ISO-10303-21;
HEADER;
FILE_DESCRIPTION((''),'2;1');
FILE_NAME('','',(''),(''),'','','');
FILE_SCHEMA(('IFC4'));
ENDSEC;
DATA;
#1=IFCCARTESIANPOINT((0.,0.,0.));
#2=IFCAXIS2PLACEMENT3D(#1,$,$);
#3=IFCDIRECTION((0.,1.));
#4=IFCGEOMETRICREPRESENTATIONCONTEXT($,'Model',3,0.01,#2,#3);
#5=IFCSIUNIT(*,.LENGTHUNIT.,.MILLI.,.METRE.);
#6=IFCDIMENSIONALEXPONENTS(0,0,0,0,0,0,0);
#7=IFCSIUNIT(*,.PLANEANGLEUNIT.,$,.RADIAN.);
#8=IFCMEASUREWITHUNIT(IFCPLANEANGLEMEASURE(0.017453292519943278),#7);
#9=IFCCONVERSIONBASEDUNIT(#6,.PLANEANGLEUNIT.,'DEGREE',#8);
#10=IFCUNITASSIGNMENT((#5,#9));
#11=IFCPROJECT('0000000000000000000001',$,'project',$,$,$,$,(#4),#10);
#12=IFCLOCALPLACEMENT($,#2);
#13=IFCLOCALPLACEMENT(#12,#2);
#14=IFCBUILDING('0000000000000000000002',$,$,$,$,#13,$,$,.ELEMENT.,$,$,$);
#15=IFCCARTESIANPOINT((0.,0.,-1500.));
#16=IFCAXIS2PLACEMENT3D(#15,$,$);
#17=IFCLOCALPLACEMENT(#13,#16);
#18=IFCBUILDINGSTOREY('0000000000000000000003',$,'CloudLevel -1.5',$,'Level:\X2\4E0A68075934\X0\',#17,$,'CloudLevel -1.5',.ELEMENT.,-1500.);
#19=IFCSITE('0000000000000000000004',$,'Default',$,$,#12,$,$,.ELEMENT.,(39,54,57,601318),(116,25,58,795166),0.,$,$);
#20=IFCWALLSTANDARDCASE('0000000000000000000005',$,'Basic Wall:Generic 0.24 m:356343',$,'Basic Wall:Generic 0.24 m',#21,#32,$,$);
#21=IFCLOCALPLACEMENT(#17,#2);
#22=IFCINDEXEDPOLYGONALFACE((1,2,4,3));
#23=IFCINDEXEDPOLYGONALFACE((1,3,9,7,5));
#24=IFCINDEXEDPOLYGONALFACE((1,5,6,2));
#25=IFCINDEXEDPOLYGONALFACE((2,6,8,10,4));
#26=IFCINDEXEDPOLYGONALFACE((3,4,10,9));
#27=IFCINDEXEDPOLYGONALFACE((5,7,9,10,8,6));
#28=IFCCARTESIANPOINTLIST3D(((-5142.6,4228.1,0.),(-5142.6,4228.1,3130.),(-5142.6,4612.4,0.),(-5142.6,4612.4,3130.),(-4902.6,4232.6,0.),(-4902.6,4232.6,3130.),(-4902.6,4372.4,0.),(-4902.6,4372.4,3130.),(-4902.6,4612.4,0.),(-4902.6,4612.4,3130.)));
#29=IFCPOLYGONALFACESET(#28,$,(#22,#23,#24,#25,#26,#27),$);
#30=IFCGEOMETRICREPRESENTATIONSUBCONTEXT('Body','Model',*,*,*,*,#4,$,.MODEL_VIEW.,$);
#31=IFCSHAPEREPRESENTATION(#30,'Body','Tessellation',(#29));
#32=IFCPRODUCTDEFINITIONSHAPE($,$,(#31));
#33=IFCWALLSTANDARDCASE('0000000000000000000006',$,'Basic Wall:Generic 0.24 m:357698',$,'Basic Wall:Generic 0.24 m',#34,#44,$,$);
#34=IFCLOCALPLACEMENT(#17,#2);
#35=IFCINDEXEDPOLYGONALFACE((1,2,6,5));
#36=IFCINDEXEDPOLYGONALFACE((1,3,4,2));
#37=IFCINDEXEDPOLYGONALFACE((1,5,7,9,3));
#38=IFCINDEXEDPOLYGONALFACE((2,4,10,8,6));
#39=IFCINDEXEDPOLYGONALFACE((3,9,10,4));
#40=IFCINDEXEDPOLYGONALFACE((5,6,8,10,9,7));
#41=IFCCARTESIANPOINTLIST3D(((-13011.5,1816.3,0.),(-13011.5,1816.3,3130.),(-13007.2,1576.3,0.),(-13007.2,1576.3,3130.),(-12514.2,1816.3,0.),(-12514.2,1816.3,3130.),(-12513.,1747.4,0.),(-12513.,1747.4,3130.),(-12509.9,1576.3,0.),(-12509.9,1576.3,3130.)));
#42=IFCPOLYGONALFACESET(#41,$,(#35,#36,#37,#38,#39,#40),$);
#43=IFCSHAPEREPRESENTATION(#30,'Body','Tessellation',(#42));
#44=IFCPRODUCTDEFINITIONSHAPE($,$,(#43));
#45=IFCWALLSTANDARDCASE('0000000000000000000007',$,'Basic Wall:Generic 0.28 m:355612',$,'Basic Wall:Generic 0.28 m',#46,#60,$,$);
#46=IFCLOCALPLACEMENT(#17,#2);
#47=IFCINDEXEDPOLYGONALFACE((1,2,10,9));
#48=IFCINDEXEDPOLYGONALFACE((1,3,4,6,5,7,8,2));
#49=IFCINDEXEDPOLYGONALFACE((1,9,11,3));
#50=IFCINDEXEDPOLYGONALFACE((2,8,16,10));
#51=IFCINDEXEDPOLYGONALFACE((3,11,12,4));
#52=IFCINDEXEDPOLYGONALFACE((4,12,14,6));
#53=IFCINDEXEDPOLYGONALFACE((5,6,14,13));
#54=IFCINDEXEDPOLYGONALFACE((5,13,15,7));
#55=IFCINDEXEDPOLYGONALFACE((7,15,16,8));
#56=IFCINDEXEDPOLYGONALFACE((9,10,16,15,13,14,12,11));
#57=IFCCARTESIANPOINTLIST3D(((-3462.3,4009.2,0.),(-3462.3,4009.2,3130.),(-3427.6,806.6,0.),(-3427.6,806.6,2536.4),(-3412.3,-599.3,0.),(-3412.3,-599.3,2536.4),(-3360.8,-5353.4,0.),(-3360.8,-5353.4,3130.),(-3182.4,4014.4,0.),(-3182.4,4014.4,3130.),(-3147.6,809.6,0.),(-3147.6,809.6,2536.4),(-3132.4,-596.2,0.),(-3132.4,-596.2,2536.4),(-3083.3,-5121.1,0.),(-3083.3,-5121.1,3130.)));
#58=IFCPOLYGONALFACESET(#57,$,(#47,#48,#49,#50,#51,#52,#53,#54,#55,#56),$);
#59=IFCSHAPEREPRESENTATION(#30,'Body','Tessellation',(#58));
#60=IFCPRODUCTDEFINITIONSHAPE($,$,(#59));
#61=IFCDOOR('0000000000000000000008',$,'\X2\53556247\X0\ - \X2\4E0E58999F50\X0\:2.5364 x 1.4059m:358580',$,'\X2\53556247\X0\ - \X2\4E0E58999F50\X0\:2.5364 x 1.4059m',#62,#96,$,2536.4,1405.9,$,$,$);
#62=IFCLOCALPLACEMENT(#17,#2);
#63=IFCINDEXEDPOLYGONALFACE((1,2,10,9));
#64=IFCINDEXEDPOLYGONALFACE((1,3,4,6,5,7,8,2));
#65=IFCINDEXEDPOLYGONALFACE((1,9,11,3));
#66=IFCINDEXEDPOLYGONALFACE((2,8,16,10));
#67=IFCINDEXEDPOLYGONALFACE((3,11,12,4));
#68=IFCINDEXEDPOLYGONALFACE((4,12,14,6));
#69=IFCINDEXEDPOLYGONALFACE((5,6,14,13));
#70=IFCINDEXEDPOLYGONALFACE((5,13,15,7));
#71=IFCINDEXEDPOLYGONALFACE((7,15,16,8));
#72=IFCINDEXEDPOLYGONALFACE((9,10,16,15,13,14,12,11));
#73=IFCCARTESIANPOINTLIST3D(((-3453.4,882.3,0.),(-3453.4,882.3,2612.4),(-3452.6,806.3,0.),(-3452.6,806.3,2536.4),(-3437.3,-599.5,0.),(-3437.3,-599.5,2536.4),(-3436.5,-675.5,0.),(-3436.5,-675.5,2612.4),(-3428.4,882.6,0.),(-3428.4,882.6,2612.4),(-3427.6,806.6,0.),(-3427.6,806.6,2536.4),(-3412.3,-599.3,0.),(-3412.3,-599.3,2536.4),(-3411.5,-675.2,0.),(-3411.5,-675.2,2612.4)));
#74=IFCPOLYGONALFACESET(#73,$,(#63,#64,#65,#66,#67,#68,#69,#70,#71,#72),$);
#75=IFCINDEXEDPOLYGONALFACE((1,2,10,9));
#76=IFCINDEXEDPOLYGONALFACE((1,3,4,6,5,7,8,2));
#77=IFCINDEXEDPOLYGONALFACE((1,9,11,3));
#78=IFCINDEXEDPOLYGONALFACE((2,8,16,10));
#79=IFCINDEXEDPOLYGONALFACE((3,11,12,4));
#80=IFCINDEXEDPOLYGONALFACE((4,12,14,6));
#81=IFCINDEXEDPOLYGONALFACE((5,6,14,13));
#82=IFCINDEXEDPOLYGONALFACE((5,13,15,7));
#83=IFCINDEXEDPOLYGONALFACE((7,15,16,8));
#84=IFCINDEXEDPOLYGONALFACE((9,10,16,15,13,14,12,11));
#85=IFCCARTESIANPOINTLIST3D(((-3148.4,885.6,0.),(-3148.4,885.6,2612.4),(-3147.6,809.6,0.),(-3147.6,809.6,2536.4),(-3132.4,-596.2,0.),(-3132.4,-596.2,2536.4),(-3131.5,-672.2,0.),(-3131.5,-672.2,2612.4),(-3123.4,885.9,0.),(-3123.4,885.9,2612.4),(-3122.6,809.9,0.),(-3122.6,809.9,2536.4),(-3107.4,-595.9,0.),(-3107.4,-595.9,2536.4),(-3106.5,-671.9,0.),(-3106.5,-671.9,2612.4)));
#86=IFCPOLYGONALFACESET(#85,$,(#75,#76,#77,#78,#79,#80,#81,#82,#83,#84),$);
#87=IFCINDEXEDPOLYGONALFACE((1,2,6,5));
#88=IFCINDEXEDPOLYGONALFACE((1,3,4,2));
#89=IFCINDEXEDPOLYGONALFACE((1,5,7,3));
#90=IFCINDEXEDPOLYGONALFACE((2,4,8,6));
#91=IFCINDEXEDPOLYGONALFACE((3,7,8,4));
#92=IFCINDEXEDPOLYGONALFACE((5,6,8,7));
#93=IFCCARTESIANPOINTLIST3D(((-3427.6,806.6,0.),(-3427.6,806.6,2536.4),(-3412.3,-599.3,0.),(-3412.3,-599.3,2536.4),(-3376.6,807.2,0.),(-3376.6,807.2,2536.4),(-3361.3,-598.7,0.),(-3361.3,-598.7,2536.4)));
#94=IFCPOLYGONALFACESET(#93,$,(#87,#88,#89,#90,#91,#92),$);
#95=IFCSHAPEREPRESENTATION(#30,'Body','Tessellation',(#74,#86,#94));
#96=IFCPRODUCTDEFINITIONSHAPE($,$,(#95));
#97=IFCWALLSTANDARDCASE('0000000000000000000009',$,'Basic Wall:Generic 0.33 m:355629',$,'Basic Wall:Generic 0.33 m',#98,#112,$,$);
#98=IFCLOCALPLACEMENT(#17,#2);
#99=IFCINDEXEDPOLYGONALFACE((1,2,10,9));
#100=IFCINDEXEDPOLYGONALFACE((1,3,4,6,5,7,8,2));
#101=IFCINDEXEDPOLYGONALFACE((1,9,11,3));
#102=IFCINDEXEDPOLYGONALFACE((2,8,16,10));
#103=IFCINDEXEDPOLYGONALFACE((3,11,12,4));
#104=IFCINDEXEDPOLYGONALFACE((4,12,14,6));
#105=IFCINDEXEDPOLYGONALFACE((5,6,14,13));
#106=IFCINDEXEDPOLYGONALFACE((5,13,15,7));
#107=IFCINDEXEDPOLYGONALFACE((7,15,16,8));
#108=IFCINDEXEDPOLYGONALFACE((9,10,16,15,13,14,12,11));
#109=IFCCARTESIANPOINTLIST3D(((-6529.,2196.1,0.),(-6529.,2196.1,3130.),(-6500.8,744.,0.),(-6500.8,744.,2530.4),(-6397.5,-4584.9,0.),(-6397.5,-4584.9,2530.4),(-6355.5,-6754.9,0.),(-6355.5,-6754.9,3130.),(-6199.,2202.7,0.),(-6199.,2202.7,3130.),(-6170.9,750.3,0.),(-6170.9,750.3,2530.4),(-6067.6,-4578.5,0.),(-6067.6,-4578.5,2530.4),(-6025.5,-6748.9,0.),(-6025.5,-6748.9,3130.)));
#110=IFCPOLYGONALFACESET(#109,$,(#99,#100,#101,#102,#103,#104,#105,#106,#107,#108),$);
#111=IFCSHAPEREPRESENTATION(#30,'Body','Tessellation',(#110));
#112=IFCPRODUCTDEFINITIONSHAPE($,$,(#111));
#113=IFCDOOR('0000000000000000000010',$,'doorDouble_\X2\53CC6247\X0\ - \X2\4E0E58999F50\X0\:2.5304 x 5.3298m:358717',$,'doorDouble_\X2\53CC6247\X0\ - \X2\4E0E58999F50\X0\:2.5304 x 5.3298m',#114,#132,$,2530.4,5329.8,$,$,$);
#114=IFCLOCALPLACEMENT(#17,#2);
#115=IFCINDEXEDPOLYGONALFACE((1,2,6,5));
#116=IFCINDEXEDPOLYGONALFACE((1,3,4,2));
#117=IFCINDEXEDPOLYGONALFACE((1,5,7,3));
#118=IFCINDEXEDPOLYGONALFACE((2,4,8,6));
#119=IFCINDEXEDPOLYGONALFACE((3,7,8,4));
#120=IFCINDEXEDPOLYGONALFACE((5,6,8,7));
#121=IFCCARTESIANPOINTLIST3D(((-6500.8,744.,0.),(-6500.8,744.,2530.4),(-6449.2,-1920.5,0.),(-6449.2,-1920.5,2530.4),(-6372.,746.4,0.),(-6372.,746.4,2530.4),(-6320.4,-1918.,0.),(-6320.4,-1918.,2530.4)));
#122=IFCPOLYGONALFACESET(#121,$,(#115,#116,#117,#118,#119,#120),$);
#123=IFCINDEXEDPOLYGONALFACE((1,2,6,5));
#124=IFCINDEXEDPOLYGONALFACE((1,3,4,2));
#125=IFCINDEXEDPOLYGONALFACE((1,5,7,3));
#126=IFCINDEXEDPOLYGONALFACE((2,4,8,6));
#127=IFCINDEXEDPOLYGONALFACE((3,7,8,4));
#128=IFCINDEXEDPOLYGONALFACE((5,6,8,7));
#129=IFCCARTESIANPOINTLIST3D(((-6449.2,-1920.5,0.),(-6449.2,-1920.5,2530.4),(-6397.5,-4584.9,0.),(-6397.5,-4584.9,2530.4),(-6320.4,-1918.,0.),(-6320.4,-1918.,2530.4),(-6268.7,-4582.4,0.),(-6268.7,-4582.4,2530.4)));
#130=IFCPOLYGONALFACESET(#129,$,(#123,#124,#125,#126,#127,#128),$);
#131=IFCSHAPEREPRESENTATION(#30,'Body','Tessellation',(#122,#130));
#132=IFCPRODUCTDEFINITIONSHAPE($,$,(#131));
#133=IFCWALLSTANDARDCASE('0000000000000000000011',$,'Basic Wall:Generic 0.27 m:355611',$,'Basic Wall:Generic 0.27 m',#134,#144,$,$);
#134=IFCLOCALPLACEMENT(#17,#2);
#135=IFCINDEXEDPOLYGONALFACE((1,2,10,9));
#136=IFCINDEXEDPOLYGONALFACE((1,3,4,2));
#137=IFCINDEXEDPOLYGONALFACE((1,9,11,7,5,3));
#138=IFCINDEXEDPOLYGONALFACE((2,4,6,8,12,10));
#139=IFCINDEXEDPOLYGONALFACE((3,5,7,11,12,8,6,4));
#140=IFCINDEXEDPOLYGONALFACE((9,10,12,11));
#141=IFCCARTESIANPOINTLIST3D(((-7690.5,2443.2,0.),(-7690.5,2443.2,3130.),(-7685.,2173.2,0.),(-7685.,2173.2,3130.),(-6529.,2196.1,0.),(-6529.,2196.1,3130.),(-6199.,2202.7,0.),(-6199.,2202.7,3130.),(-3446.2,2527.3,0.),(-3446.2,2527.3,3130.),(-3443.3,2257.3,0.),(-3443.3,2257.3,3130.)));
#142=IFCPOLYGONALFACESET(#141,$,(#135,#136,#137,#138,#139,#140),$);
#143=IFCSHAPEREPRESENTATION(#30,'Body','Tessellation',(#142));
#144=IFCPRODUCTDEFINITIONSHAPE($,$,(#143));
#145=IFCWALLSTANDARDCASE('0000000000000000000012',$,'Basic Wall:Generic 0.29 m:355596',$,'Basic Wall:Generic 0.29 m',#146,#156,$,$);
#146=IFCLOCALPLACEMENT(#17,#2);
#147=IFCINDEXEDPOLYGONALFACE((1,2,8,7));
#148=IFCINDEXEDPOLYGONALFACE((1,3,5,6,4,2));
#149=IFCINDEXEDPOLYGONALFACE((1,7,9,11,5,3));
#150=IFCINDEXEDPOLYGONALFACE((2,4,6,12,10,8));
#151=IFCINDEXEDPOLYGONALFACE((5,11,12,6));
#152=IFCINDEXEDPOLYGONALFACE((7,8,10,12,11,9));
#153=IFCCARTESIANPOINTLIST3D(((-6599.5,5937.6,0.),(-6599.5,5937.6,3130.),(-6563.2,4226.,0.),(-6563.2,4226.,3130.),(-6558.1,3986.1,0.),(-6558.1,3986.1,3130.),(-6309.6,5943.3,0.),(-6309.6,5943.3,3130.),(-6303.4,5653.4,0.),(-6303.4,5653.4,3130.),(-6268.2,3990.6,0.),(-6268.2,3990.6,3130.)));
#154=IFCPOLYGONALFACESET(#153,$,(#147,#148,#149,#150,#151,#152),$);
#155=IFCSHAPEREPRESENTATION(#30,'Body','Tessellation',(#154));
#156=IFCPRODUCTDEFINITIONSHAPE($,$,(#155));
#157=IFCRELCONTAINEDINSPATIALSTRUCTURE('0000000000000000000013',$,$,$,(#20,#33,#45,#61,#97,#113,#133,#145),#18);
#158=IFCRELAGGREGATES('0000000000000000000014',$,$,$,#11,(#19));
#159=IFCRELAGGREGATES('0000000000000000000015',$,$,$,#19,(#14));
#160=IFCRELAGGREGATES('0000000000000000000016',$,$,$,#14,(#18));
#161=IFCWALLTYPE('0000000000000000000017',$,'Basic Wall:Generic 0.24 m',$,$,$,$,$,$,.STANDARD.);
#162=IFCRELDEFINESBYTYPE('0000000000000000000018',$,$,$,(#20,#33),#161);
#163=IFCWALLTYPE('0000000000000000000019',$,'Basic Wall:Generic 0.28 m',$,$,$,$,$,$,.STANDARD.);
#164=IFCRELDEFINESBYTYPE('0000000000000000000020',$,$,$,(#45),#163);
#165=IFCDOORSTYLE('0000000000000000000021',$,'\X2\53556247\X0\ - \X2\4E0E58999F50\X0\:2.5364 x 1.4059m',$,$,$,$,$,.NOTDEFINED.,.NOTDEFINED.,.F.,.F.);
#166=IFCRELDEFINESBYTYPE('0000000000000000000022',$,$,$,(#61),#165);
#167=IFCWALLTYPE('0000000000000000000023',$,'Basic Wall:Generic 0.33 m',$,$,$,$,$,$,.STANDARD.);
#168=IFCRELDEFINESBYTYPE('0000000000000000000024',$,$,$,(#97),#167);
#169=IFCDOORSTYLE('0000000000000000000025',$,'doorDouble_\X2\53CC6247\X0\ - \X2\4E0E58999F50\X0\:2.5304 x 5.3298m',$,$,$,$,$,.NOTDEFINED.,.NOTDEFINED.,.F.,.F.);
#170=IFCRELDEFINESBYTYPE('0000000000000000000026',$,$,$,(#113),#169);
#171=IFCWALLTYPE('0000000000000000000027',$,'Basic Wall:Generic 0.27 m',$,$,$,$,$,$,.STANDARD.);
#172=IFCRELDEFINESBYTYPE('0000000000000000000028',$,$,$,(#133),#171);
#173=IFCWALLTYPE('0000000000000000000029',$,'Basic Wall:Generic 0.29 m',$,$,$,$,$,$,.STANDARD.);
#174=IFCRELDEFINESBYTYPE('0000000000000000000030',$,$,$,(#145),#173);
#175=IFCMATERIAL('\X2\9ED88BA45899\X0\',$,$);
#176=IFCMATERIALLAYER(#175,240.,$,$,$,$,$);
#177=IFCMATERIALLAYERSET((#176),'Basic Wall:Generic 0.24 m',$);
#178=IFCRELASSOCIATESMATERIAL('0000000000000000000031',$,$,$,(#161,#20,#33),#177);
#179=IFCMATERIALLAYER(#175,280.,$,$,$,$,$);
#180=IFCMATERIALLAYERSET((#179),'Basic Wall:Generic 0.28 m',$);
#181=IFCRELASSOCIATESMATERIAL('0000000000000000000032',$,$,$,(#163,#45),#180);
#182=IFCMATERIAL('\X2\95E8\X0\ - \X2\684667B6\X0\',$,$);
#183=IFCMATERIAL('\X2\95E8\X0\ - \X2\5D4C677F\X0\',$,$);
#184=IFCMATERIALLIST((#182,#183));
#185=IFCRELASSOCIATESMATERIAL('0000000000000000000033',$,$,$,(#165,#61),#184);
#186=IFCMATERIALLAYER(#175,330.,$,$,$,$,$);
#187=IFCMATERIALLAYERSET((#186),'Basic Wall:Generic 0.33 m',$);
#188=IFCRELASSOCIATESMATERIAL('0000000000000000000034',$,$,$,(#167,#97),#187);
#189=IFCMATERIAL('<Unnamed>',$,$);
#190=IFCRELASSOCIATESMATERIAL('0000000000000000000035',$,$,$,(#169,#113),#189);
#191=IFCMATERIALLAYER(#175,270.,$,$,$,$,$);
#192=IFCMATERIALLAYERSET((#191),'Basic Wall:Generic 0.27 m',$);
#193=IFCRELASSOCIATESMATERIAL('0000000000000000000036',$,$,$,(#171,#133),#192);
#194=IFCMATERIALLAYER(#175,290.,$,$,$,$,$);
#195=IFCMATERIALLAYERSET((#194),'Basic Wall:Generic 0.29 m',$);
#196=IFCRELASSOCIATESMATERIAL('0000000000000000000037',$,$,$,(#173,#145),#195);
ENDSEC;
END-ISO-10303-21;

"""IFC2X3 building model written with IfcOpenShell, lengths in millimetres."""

from ifc_helpers import new_model, entity, si_unit, converted_unit, direction, frame, frame_2d, origin, origin_2d_with_axis, place, context, subcontext, project, spatial, polyline, rectangle, outline, extrude, source, transform, mapped, material, material_list, layer, layer_set, layer_usage, type_object, type_shapes, element, fill, save


model = new_model("IFC2X3")

# Units and contexts
model_context = context("Model", 3, precision=0.01, world=origin(), true_north=direction((0.0, 1.0)))
body_context = subcontext(model_context, "Body", "Model", "MODEL_VIEW")
ifc_project = project(units=[si_unit("LENGTHUNIT", "METRE", prefix="MILLI"), converted_unit("PLANEANGLEUNIT", "DEGREE", entity("IfcPlaneAngleMeasure", 0.017453292519943278), si_unit("PLANEANGLEUNIT", "RADIAN"), dimensions=[0, 0, 0, 0, 0, 0, 0])], contexts=[model_context])

# Site, building, storey
site_placement = place(None, origin())
site = spatial("IfcSite", under=ifc_project, at=site_placement, Name="Default", CompositionType="ELEMENT", RefLatitude=(39, 54, 57, 601318), RefLongitude=(116, 25, 58, 795166), RefElevation=0.0)
building_placement = place(site_placement, origin())
building = spatial("IfcBuilding", under=site, at=building_placement, CompositionType="ELEMENT")
storey_placement = place(building_placement, frame((0.0, 0.0, -1500.0)))
storey = spatial("IfcBuildingStorey", under=building, at=storey_placement, Name="CloudLevel -1.5", ObjectType="Level:上标头", LongName="CloudLevel -1.5", CompositionType="ELEMENT", Elevation=-1500.0)

# Shared definitions
ifc_material_1 = material(Name="默认墙")
ifc_layer_1 = layer(ifc_material_1, 240.0)
ifc_layer_set_1 = layer_set([ifc_layer_1], Name="Basic Wall:Generic 0.24 m")
ifc_layer_usage_1 = layer_usage(ifc_layer_set_1, "AXIS2", "NEGATIVE", 120.0)
wall_type_1 = type_object("IfcWallType", Name="Basic Wall:Generic 0.24 m", PredefinedType="STANDARD", material=ifc_layer_set_1)
ifc_material_2 = material(Name="门 - 框架")
ifc_material_3 = material(Name="门 - 嵌板")
ifc_material_list_1 = material_list([ifc_material_2, ifc_material_3])

# Shared definitions
ifc_material_4 = material(Name="<Unnamed>")

# Walls
wall_1_placement = place(storey_placement, frame((-5022.6, 4612.4, 0.0), z_axis=(0.0, 0.0, 1.0), x_axis=(0.0, -1.0, 0.0)))
element("IfcWallStandardCase", 1, at=wall_1_placement, inside=storey, type_object=wall_type_1, material=ifc_layer_usage_1, Name="Basic Wall:Generic 0.24 m:356343", ObjectType="Basic Wall:Generic 0.24 m", context=body_context, shape_type="SweptSolid", body=[
    extrude(outline(polyline([(384.2, -120.0), (379.8, 120.0), (240.0, 120.0), (0.0, 120.0), (0.0, -120.0), (384.2, -120.0)])), origin(), (0.0, 0.0, 1.0), 3130.0),
])
wall_2_placement = place(storey_placement, frame((-13011.5, 1696.3, 0.0)))
element("IfcWallStandardCase", 2, at=wall_2_placement, inside=storey, type_object=wall_type_1, material=ifc_layer_usage_1, Name="Basic Wall:Generic 0.24 m:357698", ObjectType="Basic Wall:Generic 0.24 m", context=body_context, shape_type="SweptSolid", body=[
    extrude(outline(polyline([(501.6, -120.0), (498.5, 51.1), (497.3, 120.0), (0.0, 120.0), (4.3, -120.0), (501.6, -120.0)])), origin(), (0.0, 0.0, 1.0), 3130.0),
])

# Walls, openings, doors
ifc_layer_2 = layer(ifc_material_1, 280.0)
ifc_layer_set_2 = layer_set([ifc_layer_2], Name="Basic Wall:Generic 0.28 m")
ifc_layer_usage_2 = layer_usage(ifc_layer_set_2, "AXIS2", "NEGATIVE", 140.0)
wall_type_2 = type_object("IfcWallType", Name="Basic Wall:Generic 0.28 m", PredefinedType="STANDARD", material=ifc_layer_set_2)
wall_3_placement = place(storey_placement, frame((-3322.3, 4012.9, 0.0), z_axis=(0.0, 0.0, 1.0), x_axis=(0.010843, -0.999941, 0.0)))
wall_3 = element("IfcWallStandardCase", 3, at=wall_3_placement, inside=storey, type_object=wall_type_2, material=ifc_layer_usage_2, Name="Basic Wall:Generic 0.28 m:355612", ObjectType="Basic Wall:Generic 0.28 m", context=body_context, shape_type="SweptSolid", body=[
    extrude(outline(polyline([(2.1, -140.0), (1484.2, -140.0), (1754.2, -140.0), (9365.3, -140.0), (9136.0, 140.0), (8537.2, 140.0), (0.0, 140.0), (2.1, -140.0)])), origin(), (0.0, 0.0, 1.0), 3130.0),
])
opening_1_placement = place(wall_3_placement, frame((4610.9, 140.0, 0.0)))
opening_1 = element("IfcOpeningElement", 4, at=opening_1_placement, cuts=wall_3, ObjectType="Opening", context=body_context, shape_type="SweptSolid", body=[
    extrude(rectangle(XDim=1405.9, YDim=2536.4, at=frame_2d((1268.2, 703.0), x_axis=(0.0, -1.0))), frame((0.0, 0.0, 0.0), z_axis=(0.0, -1.0, 0.0), x_axis=(0.0, 0.0, 1.0)), (0.0, 0.0, 1.0), 280.0),
])
door_style_1 = type_object("IfcDoorStyle", Name="单扇 - 与墙齐:2.5364 x 1.4059m", ConstructionType="NOTDEFINED", OperationType="NOTDEFINED", ParameterTakesPrecedence=False, Sizeable=False, material=ifc_material_list_1)
shared_shape_1 = source(origin(), body_context, "Body", "SweptSolid", [
    extrude(outline(polyline([(-779.0, -1325.2), (779.0, -1325.2), (779.0, 1287.2), (703.0, 1287.2), (703.0, -1249.2), (-703.0, -1249.2), (-703.0, 1287.2), (-779.0, 1287.2), (-779.0, -1325.2)])), frame((703.0, 305.0, 1287.2), z_axis=(0.0, -1.0, 0.0), x_axis=(-1.0, 0.0, 0.0)), (0.0, 0.0, 1.0), 25.0),
    extrude(outline(polyline([(-1325.2, -779.0), (1287.2, -779.0), (1287.2, -703.0), (-1249.2, -703.0), (-1249.2, 703.0), (1287.2, 703.0), (1287.2, 779.0), (-1325.2, 779.0), (-1325.2, -779.0)])), frame((703.0, 0.0, 1287.2), z_axis=(0.0, -1.0, 0.0), x_axis=(0.0, 0.0, -1.0)), (0.0, 0.0, 1.0), 25.0),
    extrude(rectangle(XDim=1405.9, YDim=51.0, at=origin_2d_with_axis()), frame((703.0, 254.5, 0.0)), (0.0, 0.0, 1.0), 2536.4),
])
type_shapes(door_style_1, [shared_shape_1])
door_1_placement = place(opening_1_placement, frame((0.0, 0.0, 0.0), z_axis=(0.0, 0.0, 1.0), x_axis=(-1.0, 0.0, 0.0)))
door_1 = element("IfcDoor", 5, at=door_1_placement, inside=storey, type_object=door_style_1, material=ifc_material_list_1, Name="单扇 - 与墙齐:2.5364 x 1.4059m:358580", ObjectType="单扇 - 与墙齐:2.5364 x 1.4059m", OverallHeight=2536.4, OverallWidth=1405.9, context=body_context, shape_type="MappedRepresentation", body=[
    mapped(shared_shape_1, transform((0.0, 0.0, 0.0), scale=1.0)),
])
fill(opening_1, door_1)
ifc_layer_3 = layer(ifc_material_1, 330.0)
ifc_layer_set_3 = layer_set([ifc_layer_3], Name="Basic Wall:Generic 0.33 m")
ifc_layer_usage_3 = layer_usage(ifc_layer_set_3, "AXIS2", "NEGATIVE", 165.0)
wall_type_3 = type_object("IfcWallType", Name="Basic Wall:Generic 0.33 m", PredefinedType="STANDARD", material=ifc_layer_set_3)
wall_4_placement = place(storey_placement, frame((-6364.0, 2199.5, 0.0), z_axis=(0.0, 0.0, 1.0), x_axis=(0.01938, -0.999812, 0.0)))
wall_4 = element("IfcWallStandardCase", 6, at=wall_4_placement, inside=storey, type_object=wall_type_3, material=ifc_layer_usage_3, Name="Basic Wall:Generic 0.33 m:355629", ObjectType="Basic Wall:Generic 0.33 m", context=body_context, shape_type="SweptSolid", body=[
    extrude(outline(polyline([(0.1, -165.0), (8952.8, -165.0), (8953.3, 165.0), (8874.4, 165.0), (8634.0, 165.0), (0.0, 165.0), (0.1, -165.0)])), origin(), (0.0, 0.0, 1.0), 3130.0),
])
opening_2_placement = place(wall_4_placement, frame((1452.6, -165.0, 0.0)))
opening_2 = element("IfcOpeningElement", 7, at=opening_2_placement, cuts=wall_4, ObjectType="Opening", context=body_context, shape_type="SweptSolid", body=[
    extrude(rectangle(XDim=2530.4, YDim=5329.8, at=frame_2d((1265.2, 2664.9), x_axis=(1.0, 0.0))), frame((0.0, 0.0, 0.0), z_axis=(0.0, 1.0, 0.0), x_axis=(0.0, 0.0, 1.0)), (0.0, 0.0, 1.0), 330.0),
])
door_style_2 = type_object("IfcDoorStyle", Name="doorDouble_双扇 - 与墙齐:2.5304 x 5.3298m", ConstructionType="NOTDEFINED", OperationType="NOTDEFINED", ParameterTakesPrecedence=False, Sizeable=False, material=ifc_material_4)
shared_shape_2 = source(origin(), body_context, "Body", "SweptSolid", [
    extrude(rectangle(XDim=2664.9, YDim=128.8, at=origin_2d_with_axis()), frame((3997.4, 265.6, 0.0), z_axis=(0.0, 0.0, 1.0), x_axis=(-1.0, 0.0, 0.0)), (0.0, 0.0, 1.0), 2530.4),
    extrude(rectangle(XDim=2664.9, YDim=128.8, at=origin_2d_with_axis()), frame((1332.5, 265.6, 0.0), z_axis=(0.0, 0.0, 1.0), x_axis=(-1.0, 0.0, 0.0)), (0.0, 0.0, 1.0), 2530.4),
])
type_shapes(door_style_2, [shared_shape_2])
door_2_placement = place(opening_2_placement, frame((5329.8, 330.0, 0.0), z_axis=(0.0, 0.0, 1.0), x_axis=(-1.0, 0.0, 0.0)))
door_2 = element("IfcDoor", 8, at=door_2_placement, inside=storey, type_object=door_style_2, material=ifc_material_4, Name="doorDouble_双扇 - 与墙齐:2.5304 x 5.3298m:358717", ObjectType="doorDouble_双扇 - 与墙齐:2.5304 x 5.3298m", OverallHeight=2530.4, OverallWidth=5329.8, context=body_context, shape_type="MappedRepresentation", body=[
    mapped(shared_shape_2, transform((0.0, 0.0, 0.0), scale=1.0)),
])
fill(opening_2, door_2)

# Walls
ifc_layer_4 = layer(ifc_material_1, 270.0)
ifc_layer_set_4 = layer_set([ifc_layer_4], Name="Basic Wall:Generic 0.27 m")
ifc_layer_usage_4 = layer_usage(ifc_layer_set_4, "AXIS2", "NEGATIVE", 135.0)
wall_type_4 = type_object("IfcWallType", Name="Basic Wall:Generic 0.27 m", PredefinedType="STANDARD", material=ifc_layer_set_4)
wall_5_placement = place(storey_placement, frame((-3443.6, 2392.3, 0.0), z_axis=(0.0, 0.0, 1.0), x_axis=(-0.999804, -0.01981, 0.0)))
element("IfcWallStandardCase", 9, at=wall_5_placement, inside=storey, type_object=wall_type_4, material=ifc_layer_usage_4, Name="Basic Wall:Generic 0.27 m:355611", ObjectType="Basic Wall:Generic 0.27 m", context=body_context, shape_type="SweptSolid", body=[
    extrude(outline(polyline([(4245.1, -135.0), (4244.9, 135.0), (3088.7, 135.0), (2758.7, 135.0), (2.4, 135.0), (0.0, -135.0), (4245.1, -135.0)])), origin(), (0.0, 0.0, 1.0), 3130.0),
])
ifc_layer_5 = layer(ifc_material_1, 290.0)
ifc_layer_set_5 = layer_set([ifc_layer_5], Name="Basic Wall:Generic 0.29 m")
ifc_layer_usage_5 = layer_usage(ifc_layer_set_5, "AXIS2", "NEGATIVE", 145.0)
wall_type_5 = type_object("IfcWallType", Name="Basic Wall:Generic 0.29 m", PredefinedType="STANDARD", material=ifc_layer_set_5)
wall_6_placement = place(storey_placement, frame((-6413.1, 3987.6, 0.0), z_axis=(0.0, 0.0, 1.0), x_axis=(-0.021205, 0.999775, 0.0)))
element("IfcWallStandardCase", 10, at=wall_6_placement, inside=storey, type_object=wall_type_5, material=ifc_layer_usage_5, Name="Basic Wall:Generic 0.29 m:355596", ObjectType="Basic Wall:Generic 0.29 m", context=body_context, shape_type="SweptSolid", body=[
    extrude(outline(polyline([(1953.1, -145.0), (1953.6, 145.0), (241.6, 145.0), (1.6, 145.0), (0.0, -145.0), (1663.1, -145.0), (1953.1, -145.0)])), origin(), (0.0, 0.0, 1.0), 3130.0),
])

save(model, "model.ifc")
